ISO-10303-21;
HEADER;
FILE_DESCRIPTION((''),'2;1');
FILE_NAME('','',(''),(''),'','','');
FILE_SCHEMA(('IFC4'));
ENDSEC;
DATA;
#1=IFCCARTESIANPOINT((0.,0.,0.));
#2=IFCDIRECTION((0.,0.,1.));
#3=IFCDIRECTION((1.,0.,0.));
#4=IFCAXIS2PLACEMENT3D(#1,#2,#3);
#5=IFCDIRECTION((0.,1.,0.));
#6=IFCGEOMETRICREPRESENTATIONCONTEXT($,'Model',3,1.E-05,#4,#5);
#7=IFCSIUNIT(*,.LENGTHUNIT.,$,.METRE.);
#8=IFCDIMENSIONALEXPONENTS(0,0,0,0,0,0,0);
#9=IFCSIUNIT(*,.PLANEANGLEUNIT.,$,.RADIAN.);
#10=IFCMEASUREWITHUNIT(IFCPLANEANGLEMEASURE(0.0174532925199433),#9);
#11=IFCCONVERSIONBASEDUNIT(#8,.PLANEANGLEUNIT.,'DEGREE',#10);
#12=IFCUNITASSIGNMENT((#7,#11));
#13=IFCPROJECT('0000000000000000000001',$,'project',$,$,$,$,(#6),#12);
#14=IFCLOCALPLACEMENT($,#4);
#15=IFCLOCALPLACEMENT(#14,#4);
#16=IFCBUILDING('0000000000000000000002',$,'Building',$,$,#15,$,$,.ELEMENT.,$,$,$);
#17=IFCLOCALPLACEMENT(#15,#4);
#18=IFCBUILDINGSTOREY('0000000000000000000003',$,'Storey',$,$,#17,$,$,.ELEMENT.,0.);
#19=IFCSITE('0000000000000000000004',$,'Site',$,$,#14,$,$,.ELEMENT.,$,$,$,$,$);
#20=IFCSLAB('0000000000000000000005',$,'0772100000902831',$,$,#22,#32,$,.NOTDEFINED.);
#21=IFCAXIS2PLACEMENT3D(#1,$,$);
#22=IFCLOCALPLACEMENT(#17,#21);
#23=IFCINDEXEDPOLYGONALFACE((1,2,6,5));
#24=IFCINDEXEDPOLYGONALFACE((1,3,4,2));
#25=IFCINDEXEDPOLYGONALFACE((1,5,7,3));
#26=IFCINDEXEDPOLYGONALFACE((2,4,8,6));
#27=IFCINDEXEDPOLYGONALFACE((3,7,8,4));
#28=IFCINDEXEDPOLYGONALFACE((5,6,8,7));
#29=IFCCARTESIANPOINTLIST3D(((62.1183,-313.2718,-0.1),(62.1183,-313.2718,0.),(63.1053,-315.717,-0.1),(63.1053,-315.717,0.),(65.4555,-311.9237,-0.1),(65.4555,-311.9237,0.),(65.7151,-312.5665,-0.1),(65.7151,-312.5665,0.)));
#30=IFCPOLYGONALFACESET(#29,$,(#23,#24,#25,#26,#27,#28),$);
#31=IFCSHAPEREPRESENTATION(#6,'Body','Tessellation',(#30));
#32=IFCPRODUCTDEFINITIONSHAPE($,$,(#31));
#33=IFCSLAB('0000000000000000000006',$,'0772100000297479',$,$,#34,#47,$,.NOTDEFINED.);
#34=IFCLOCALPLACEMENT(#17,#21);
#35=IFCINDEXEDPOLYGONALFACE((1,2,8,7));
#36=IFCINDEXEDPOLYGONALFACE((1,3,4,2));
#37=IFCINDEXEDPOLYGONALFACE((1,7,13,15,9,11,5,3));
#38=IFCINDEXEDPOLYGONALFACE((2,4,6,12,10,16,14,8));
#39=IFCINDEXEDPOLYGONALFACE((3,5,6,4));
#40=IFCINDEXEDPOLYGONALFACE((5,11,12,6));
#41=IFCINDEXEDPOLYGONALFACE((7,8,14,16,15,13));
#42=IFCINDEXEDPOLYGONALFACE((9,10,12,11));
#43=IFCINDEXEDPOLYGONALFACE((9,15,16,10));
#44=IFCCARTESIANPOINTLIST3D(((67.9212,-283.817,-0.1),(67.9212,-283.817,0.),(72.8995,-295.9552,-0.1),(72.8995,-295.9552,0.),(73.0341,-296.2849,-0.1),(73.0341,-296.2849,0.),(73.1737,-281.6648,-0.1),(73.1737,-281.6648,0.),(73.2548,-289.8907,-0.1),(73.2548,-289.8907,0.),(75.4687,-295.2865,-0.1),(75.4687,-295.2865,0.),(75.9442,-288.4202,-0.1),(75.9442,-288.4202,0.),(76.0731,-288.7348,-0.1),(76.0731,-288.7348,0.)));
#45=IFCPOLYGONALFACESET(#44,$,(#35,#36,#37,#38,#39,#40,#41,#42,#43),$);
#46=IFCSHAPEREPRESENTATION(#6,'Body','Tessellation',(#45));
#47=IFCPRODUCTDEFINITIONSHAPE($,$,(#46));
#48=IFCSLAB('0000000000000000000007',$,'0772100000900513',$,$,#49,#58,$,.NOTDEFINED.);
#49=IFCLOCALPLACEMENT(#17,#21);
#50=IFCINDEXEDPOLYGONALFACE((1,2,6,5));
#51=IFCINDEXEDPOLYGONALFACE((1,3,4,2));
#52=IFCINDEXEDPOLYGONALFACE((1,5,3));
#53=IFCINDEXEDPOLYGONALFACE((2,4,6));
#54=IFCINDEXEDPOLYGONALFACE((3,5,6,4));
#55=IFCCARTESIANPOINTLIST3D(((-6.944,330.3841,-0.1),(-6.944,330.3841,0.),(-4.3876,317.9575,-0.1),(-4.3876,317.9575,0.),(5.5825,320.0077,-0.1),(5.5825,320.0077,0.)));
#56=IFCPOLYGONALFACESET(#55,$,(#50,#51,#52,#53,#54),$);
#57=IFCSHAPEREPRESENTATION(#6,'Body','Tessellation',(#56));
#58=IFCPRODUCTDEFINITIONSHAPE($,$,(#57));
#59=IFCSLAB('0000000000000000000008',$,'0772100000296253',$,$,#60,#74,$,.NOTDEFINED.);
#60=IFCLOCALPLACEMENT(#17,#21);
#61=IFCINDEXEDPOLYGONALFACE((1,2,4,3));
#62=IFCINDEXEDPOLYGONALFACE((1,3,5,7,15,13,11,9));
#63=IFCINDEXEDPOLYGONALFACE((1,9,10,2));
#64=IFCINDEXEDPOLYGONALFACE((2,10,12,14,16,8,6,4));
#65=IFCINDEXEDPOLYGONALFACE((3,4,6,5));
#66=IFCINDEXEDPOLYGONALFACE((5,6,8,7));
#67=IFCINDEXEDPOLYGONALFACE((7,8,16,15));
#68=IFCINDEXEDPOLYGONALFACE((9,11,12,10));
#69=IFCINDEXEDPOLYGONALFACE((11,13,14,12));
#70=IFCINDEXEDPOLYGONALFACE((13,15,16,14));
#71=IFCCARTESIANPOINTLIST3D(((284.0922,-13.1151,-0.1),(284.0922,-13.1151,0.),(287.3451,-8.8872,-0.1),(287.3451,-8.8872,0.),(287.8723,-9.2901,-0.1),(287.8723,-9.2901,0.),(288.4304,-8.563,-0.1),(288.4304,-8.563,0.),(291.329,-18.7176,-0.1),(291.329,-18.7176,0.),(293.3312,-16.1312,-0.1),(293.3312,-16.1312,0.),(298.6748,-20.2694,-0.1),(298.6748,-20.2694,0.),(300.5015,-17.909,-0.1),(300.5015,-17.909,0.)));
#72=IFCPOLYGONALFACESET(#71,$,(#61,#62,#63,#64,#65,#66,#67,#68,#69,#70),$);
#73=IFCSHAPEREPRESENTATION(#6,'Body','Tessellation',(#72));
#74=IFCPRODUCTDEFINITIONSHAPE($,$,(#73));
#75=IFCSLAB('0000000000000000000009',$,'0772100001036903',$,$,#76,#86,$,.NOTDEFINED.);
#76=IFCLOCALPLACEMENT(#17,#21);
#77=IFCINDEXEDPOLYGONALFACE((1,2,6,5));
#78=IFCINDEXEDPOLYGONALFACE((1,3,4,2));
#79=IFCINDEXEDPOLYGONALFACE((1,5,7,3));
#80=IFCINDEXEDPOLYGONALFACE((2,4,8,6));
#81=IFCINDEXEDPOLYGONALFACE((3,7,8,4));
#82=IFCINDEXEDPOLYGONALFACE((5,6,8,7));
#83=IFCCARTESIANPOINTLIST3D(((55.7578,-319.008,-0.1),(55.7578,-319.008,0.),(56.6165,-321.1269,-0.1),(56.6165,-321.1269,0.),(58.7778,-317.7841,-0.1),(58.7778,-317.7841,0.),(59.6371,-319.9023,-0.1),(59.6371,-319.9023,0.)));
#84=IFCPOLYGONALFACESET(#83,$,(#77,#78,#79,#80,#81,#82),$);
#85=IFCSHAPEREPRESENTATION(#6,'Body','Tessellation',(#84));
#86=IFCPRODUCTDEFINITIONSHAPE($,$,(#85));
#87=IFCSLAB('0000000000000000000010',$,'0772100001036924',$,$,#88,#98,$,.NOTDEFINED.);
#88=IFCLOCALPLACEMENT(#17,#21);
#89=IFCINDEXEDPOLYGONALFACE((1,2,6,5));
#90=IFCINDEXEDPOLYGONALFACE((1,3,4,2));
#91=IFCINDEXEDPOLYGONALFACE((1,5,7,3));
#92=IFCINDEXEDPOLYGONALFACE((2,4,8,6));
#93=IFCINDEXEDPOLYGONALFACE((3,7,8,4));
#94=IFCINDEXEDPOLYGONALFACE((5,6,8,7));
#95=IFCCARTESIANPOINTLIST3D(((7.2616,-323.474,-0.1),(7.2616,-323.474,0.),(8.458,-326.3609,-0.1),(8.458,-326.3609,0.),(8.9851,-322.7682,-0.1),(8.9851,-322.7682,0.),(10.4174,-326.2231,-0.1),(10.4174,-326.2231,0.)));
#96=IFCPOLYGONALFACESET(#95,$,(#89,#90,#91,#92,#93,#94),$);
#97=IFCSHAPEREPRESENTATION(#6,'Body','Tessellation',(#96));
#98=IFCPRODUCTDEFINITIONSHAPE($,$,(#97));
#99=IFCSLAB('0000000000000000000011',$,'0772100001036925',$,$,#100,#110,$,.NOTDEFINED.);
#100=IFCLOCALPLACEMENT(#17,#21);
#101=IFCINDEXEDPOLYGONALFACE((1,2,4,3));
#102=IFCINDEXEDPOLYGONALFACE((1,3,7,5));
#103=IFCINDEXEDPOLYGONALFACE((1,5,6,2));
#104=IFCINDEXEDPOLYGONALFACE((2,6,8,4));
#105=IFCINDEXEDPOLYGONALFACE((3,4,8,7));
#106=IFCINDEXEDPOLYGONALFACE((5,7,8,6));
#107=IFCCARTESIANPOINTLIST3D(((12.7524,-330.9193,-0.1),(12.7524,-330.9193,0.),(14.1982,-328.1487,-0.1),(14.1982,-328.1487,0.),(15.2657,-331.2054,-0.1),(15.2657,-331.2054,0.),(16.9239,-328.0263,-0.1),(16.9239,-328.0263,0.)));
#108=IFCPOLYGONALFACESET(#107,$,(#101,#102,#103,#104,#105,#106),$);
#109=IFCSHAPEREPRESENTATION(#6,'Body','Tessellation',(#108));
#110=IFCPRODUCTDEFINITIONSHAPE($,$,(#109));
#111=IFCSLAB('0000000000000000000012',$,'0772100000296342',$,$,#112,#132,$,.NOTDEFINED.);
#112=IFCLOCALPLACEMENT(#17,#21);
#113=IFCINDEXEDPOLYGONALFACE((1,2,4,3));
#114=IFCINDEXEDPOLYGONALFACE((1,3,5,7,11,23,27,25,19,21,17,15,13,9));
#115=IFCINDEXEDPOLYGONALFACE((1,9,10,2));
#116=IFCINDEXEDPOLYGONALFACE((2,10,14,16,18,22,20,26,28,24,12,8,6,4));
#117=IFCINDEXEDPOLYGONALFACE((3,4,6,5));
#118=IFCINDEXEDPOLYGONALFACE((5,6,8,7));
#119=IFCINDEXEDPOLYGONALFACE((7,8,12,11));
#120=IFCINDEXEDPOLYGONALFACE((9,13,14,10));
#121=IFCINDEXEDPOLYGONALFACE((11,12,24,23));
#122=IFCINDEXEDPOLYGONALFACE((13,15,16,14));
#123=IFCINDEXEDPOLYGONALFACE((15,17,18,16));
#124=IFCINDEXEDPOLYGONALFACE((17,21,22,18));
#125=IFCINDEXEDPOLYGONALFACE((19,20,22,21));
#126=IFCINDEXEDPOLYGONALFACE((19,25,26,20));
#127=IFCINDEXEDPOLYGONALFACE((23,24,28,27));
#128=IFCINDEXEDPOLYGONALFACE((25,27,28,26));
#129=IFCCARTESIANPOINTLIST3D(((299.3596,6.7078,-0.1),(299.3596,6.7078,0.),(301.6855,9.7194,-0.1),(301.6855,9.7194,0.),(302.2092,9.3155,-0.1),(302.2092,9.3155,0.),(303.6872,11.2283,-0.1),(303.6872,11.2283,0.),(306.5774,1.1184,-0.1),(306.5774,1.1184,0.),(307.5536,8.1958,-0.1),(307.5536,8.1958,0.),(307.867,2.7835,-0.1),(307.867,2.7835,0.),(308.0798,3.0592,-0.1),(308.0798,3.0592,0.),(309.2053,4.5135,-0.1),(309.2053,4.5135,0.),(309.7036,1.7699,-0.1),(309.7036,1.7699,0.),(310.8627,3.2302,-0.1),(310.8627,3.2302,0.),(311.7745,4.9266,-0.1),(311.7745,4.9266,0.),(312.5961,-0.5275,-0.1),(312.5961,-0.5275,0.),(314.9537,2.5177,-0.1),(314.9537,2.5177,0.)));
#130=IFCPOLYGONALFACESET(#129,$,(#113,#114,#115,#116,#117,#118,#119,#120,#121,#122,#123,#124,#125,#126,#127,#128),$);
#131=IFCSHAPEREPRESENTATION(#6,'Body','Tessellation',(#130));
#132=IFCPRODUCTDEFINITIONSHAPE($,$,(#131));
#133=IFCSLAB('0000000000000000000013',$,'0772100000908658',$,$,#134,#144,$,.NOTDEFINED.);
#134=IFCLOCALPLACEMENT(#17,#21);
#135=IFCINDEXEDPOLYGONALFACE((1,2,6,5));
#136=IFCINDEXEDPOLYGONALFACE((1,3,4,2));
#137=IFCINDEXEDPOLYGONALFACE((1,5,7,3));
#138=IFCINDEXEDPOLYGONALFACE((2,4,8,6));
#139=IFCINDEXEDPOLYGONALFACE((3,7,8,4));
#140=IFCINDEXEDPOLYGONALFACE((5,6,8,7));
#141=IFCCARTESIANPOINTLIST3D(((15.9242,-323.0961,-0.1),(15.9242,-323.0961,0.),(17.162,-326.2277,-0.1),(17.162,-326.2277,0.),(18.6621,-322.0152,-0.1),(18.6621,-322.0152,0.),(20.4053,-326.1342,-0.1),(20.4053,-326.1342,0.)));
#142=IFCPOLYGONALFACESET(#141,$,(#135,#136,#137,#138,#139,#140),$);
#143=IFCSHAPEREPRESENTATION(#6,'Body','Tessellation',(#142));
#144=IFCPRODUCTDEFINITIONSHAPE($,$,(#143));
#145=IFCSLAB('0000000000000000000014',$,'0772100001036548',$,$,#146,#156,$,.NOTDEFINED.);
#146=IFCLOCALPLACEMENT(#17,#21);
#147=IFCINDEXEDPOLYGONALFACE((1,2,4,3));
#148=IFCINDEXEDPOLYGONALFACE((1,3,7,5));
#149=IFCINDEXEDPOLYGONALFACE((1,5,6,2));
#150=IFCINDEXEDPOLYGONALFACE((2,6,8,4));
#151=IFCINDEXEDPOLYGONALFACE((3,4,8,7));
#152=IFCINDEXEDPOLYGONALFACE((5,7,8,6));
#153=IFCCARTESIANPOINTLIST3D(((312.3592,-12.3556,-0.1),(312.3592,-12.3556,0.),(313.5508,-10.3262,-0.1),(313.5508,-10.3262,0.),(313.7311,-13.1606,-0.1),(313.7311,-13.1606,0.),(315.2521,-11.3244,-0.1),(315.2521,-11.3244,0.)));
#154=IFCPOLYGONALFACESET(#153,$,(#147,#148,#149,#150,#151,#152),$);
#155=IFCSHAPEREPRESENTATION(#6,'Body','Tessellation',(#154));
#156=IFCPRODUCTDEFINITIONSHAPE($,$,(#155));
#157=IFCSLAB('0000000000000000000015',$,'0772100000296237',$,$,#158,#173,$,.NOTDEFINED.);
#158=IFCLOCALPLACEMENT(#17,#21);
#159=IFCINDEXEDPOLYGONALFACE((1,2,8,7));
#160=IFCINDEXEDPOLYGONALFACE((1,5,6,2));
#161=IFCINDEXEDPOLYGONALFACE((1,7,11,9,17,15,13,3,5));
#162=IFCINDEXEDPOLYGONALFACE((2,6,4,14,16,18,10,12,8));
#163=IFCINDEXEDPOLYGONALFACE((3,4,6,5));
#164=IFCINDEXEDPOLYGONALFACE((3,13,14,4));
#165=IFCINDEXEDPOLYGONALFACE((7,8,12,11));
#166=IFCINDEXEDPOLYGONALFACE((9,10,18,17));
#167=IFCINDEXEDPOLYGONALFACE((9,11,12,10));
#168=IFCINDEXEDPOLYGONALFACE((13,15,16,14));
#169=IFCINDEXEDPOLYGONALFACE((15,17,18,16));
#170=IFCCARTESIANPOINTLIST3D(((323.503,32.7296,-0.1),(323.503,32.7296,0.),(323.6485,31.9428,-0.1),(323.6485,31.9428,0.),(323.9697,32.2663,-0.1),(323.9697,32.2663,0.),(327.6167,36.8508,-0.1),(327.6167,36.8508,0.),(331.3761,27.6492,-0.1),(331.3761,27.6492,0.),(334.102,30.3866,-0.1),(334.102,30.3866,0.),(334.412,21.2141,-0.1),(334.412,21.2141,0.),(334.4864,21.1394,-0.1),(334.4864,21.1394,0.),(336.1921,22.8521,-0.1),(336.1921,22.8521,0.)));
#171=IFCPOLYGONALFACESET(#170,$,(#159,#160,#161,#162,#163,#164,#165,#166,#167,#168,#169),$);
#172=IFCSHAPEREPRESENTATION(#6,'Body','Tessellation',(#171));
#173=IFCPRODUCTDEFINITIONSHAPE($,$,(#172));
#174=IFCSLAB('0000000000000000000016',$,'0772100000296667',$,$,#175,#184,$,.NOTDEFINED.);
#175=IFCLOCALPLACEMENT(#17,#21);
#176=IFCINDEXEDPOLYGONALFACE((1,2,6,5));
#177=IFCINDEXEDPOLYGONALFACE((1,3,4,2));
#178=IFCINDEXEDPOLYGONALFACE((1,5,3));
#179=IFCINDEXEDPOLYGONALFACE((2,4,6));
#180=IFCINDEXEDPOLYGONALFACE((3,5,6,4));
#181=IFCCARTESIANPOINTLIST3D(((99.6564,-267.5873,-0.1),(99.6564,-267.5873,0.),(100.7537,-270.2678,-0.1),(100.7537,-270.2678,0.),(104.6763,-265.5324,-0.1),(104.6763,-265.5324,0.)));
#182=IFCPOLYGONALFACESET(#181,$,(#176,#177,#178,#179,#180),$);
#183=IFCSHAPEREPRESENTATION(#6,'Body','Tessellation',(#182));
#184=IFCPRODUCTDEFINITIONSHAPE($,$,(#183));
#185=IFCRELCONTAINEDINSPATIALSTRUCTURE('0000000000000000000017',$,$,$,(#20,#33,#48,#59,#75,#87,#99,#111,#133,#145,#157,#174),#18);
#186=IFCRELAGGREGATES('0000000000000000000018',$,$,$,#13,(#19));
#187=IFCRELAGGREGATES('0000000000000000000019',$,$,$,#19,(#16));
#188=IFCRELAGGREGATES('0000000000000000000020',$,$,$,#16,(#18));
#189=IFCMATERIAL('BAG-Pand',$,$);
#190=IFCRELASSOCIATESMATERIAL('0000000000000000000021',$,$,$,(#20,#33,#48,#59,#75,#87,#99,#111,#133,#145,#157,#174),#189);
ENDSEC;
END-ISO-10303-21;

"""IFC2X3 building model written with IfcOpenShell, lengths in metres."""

from ifc_helpers import new_model, entity, si_unit, converted_unit, direction, frame, origin_with_axes, place, context, project, spatial, polyline, outline, extrude, material, element, save


model = new_model("IFC2X3")

# Units and contexts
model_context = context("Model", 3, precision=1e-05, world=origin_with_axes(), true_north=direction((0.0, 1.0, 0.0)))
ifc_project = project(units=[si_unit("LENGTHUNIT", "METRE"), converted_unit("PLANEANGLEUNIT", "DEGREE", entity("IfcPlaneAngleMeasure", 0.0174532925199433), si_unit("PLANEANGLEUNIT", "RADIAN"), dimensions=[0, 0, 0, 0, 0, 0, 0])], contexts=[model_context])

# Site, building, storey
site_placement = place(None, origin_with_axes())
site = spatial("IfcSite", under=ifc_project, at=site_placement, Name="Site", CompositionType="ELEMENT")
building_placement = place(site_placement, origin_with_axes())
building = spatial("IfcBuilding", under=site, at=building_placement, Name="Building", CompositionType="ELEMENT")
storey_placement = place(building_placement, origin_with_axes())
storey = spatial("IfcBuildingStorey", under=building, at=storey_placement, Name="Storey", CompositionType="ELEMENT", Elevation=0.0)

# Slabs
ifc_material = material(Name="BAG-Pand")
slab_1_placement = place(storey_placement, frame((0.0, 0.0, -0.1), z_axis=(0.0, 0.0, 1.0), x_axis=(1.0, 0.0, 0.0)))
element("IfcSlab", 1, at=slab_1_placement, inside=storey, material=ifc_material, Name="0772100000902831", PredefinedType="NOTDEFINED", context=model_context, shape_type="SweptSolid", body=[
    extrude(outline(polyline([(62.1183, -313.2718), (65.4555, -311.9237), (65.7151, -312.5665), (63.1053, -315.717), (62.1183, -313.2718)])), origin_with_axes(), (0.0, 0.0, 1.0), 0.1),
])
slab_2_placement = place(storey_placement, frame((0.0, 0.0, -0.1), z_axis=(0.0, 0.0, 1.0), x_axis=(1.0, 0.0, 0.0)))
element("IfcSlab", 2, at=slab_2_placement, inside=storey, material=ifc_material, Name="0772100000297479", PredefinedType="NOTDEFINED", context=model_context, shape_type="SweptSolid", body=[
    extrude(outline(polyline([(73.0341, -296.2849), (72.8995, -295.9552), (67.9212, -283.817), (73.1737, -281.6648), (75.9442, -288.4202), (76.0731, -288.7348), (73.2548, -289.8907), (75.4687, -295.2865), (73.0341, -296.2849)])), origin_with_axes(), (0.0, 0.0, 1.0), 0.1),
])
slab_3_placement = place(storey_placement, frame((0.0, 0.0, -0.1), z_axis=(0.0, 0.0, 1.0), x_axis=(1.0, 0.0, 0.0)))
element("IfcSlab", 3, at=slab_3_placement, inside=storey, material=ifc_material, Name="0772100000900513", PredefinedType="NOTDEFINED", context=model_context, shape_type="SweptSolid", body=[
    extrude(outline(polyline([(-4.3876, 317.9575), (-6.944, 330.3841), (5.5825, 320.0077), (-4.3876, 317.9575)])), origin_with_axes(), (0.0, 0.0, 1.0), 0.1),
])
slab_4_placement = place(storey_placement, frame((0.0, 0.0, -0.1), z_axis=(0.0, 0.0, 1.0), x_axis=(1.0, 0.0, 0.0)))
element("IfcSlab", 4, at=slab_4_placement, inside=storey, material=ifc_material, Name="0772100000296253", PredefinedType="NOTDEFINED", context=model_context, shape_type="SweptSolid", body=[
    extrude(outline(polyline([(287.3451, -8.8872), (287.8723, -9.2901), (288.4304, -8.563), (300.5015, -17.909), (298.6748, -20.2694), (293.3312, -16.1312), (291.329, -18.7176), (284.0922, -13.1151), (287.3451, -8.8872)])), origin_with_axes(), (0.0, 0.0, 1.0), 0.1),
])
slab_5_placement = place(storey_placement, frame((0.0, 0.0, -0.1), z_axis=(0.0, 0.0, 1.0), x_axis=(1.0, 0.0, 0.0)))
element("IfcSlab", 5, at=slab_5_placement, inside=storey, material=ifc_material, Name="0772100001036903", PredefinedType="NOTDEFINED", context=model_context, shape_type="SweptSolid", body=[
    extrude(outline(polyline([(55.7578, -319.008), (58.7778, -317.7841), (59.6371, -319.9023), (56.6165, -321.1269), (55.7578, -319.008)])), origin_with_axes(), (0.0, 0.0, 1.0), 0.1),
])
slab_6_placement = place(storey_placement, frame((0.0, 0.0, -0.1), z_axis=(0.0, 0.0, 1.0), x_axis=(1.0, 0.0, 0.0)))
element("IfcSlab", 6, at=slab_6_placement, inside=storey, material=ifc_material, Name="0772100001036924", PredefinedType="NOTDEFINED", context=model_context, shape_type="SweptSolid", body=[
    extrude(outline(polyline([(7.2616, -323.474), (8.9851, -322.7682), (10.4174, -326.2231), (8.458, -326.3609), (7.2616, -323.474)])), origin_with_axes(), (0.0, 0.0, 1.0), 0.1),
])
slab_7_placement = place(storey_placement, frame((0.0, 0.0, -0.1), z_axis=(0.0, 0.0, 1.0), x_axis=(1.0, 0.0, 0.0)))
element("IfcSlab", 7, at=slab_7_placement, inside=storey, material=ifc_material, Name="0772100001036925", PredefinedType="NOTDEFINED", context=model_context, shape_type="SweptSolid", body=[
    extrude(outline(polyline([(14.1982, -328.1487), (16.9239, -328.0263), (15.2657, -331.2054), (12.7524, -330.9193), (14.1982, -328.1487)])), origin_with_axes(), (0.0, 0.0, 1.0), 0.1),
])
slab_8_placement = place(storey_placement, frame((0.0, 0.0, -0.1), z_axis=(0.0, 0.0, 1.0), x_axis=(1.0, 0.0, 0.0)))
element("IfcSlab", 8, at=slab_8_placement, inside=storey, material=ifc_material, Name="0772100000296342", PredefinedType="NOTDEFINED", context=model_context, shape_type="SweptSolid", body=[
    extrude(outline(polyline([(301.6855, 9.7194), (302.2092, 9.3155), (303.6872, 11.2283), (307.5536, 8.1958), (311.7745, 4.9266), (314.9537, 2.5177), (312.5961, -0.5275), (309.7036, 1.7699), (310.8627, 3.2302), (309.2053, 4.5135), (308.0798, 3.0592), (307.867, 2.7835), (306.5774, 1.1184), (299.3596, 6.7078), (301.6855, 9.7194)])), origin_with_axes(), (0.0, 0.0, 1.0), 0.1),
])
slab_9_placement = place(storey_placement, frame((0.0, 0.0, -0.1), z_axis=(0.0, 0.0, 1.0), x_axis=(1.0, 0.0, 0.0)))
element("IfcSlab", 9, at=slab_9_placement, inside=storey, material=ifc_material, Name="0772100000908658", PredefinedType="NOTDEFINED", context=model_context, shape_type="SweptSolid", body=[
    extrude(outline(polyline([(15.9242, -323.0961), (18.6621, -322.0152), (20.4053, -326.1342), (17.162, -326.2277), (15.9242, -323.0961)])), origin_with_axes(), (0.0, 0.0, 1.0), 0.1),
])
slab_10_placement = place(storey_placement, frame((0.0, 0.0, -0.1), z_axis=(0.0, 0.0, 1.0), x_axis=(1.0, 0.0, 0.0)))
element("IfcSlab", 10, at=slab_10_placement, inside=storey, material=ifc_material, Name="0772100001036548", PredefinedType="NOTDEFINED", context=model_context, shape_type="SweptSolid", body=[
    extrude(outline(polyline([(312.3592, -12.3556), (313.5508, -10.3262), (315.2521, -11.3244), (313.7311, -13.1606), (312.3592, -12.3556)])), origin_with_axes(), (0.0, 0.0, 1.0), 0.1),
])
slab_11_placement = place(storey_placement, frame((0.0, 0.0, -0.1), z_axis=(0.0, 0.0, 1.0), x_axis=(1.0, 0.0, 0.0)))
element("IfcSlab", 11, at=slab_11_placement, inside=storey, material=ifc_material, Name="0772100000296237", PredefinedType="NOTDEFINED", context=model_context, shape_type="SweptSolid", body=[
    extrude(outline(polyline([(334.412, 21.2141), (323.6485, 31.9428), (323.9697, 32.2663), (323.503, 32.7296), (327.6167, 36.8508), (334.102, 30.3866), (331.3761, 27.6492), (336.1921, 22.8521), (334.4864, 21.1394), (334.412, 21.2141)])), origin_with_axes(), (0.0, 0.0, 1.0), 0.1),
])
slab_12_placement = place(storey_placement, frame((0.0, 0.0, -0.1), z_axis=(0.0, 0.0, 1.0), x_axis=(1.0, 0.0, 0.0)))
element("IfcSlab", 12, at=slab_12_placement, inside=storey, material=ifc_material, Name="0772100000296667", PredefinedType="NOTDEFINED", context=model_context, shape_type="SweptSolid", body=[
    extrude(outline(polyline([(99.6564, -267.5873), (104.6763, -265.5324), (100.7537, -270.2678), (99.6564, -267.5873)])), origin_with_axes(), (0.0, 0.0, 1.0), 0.1),
])

save(model, "model.ifc")
